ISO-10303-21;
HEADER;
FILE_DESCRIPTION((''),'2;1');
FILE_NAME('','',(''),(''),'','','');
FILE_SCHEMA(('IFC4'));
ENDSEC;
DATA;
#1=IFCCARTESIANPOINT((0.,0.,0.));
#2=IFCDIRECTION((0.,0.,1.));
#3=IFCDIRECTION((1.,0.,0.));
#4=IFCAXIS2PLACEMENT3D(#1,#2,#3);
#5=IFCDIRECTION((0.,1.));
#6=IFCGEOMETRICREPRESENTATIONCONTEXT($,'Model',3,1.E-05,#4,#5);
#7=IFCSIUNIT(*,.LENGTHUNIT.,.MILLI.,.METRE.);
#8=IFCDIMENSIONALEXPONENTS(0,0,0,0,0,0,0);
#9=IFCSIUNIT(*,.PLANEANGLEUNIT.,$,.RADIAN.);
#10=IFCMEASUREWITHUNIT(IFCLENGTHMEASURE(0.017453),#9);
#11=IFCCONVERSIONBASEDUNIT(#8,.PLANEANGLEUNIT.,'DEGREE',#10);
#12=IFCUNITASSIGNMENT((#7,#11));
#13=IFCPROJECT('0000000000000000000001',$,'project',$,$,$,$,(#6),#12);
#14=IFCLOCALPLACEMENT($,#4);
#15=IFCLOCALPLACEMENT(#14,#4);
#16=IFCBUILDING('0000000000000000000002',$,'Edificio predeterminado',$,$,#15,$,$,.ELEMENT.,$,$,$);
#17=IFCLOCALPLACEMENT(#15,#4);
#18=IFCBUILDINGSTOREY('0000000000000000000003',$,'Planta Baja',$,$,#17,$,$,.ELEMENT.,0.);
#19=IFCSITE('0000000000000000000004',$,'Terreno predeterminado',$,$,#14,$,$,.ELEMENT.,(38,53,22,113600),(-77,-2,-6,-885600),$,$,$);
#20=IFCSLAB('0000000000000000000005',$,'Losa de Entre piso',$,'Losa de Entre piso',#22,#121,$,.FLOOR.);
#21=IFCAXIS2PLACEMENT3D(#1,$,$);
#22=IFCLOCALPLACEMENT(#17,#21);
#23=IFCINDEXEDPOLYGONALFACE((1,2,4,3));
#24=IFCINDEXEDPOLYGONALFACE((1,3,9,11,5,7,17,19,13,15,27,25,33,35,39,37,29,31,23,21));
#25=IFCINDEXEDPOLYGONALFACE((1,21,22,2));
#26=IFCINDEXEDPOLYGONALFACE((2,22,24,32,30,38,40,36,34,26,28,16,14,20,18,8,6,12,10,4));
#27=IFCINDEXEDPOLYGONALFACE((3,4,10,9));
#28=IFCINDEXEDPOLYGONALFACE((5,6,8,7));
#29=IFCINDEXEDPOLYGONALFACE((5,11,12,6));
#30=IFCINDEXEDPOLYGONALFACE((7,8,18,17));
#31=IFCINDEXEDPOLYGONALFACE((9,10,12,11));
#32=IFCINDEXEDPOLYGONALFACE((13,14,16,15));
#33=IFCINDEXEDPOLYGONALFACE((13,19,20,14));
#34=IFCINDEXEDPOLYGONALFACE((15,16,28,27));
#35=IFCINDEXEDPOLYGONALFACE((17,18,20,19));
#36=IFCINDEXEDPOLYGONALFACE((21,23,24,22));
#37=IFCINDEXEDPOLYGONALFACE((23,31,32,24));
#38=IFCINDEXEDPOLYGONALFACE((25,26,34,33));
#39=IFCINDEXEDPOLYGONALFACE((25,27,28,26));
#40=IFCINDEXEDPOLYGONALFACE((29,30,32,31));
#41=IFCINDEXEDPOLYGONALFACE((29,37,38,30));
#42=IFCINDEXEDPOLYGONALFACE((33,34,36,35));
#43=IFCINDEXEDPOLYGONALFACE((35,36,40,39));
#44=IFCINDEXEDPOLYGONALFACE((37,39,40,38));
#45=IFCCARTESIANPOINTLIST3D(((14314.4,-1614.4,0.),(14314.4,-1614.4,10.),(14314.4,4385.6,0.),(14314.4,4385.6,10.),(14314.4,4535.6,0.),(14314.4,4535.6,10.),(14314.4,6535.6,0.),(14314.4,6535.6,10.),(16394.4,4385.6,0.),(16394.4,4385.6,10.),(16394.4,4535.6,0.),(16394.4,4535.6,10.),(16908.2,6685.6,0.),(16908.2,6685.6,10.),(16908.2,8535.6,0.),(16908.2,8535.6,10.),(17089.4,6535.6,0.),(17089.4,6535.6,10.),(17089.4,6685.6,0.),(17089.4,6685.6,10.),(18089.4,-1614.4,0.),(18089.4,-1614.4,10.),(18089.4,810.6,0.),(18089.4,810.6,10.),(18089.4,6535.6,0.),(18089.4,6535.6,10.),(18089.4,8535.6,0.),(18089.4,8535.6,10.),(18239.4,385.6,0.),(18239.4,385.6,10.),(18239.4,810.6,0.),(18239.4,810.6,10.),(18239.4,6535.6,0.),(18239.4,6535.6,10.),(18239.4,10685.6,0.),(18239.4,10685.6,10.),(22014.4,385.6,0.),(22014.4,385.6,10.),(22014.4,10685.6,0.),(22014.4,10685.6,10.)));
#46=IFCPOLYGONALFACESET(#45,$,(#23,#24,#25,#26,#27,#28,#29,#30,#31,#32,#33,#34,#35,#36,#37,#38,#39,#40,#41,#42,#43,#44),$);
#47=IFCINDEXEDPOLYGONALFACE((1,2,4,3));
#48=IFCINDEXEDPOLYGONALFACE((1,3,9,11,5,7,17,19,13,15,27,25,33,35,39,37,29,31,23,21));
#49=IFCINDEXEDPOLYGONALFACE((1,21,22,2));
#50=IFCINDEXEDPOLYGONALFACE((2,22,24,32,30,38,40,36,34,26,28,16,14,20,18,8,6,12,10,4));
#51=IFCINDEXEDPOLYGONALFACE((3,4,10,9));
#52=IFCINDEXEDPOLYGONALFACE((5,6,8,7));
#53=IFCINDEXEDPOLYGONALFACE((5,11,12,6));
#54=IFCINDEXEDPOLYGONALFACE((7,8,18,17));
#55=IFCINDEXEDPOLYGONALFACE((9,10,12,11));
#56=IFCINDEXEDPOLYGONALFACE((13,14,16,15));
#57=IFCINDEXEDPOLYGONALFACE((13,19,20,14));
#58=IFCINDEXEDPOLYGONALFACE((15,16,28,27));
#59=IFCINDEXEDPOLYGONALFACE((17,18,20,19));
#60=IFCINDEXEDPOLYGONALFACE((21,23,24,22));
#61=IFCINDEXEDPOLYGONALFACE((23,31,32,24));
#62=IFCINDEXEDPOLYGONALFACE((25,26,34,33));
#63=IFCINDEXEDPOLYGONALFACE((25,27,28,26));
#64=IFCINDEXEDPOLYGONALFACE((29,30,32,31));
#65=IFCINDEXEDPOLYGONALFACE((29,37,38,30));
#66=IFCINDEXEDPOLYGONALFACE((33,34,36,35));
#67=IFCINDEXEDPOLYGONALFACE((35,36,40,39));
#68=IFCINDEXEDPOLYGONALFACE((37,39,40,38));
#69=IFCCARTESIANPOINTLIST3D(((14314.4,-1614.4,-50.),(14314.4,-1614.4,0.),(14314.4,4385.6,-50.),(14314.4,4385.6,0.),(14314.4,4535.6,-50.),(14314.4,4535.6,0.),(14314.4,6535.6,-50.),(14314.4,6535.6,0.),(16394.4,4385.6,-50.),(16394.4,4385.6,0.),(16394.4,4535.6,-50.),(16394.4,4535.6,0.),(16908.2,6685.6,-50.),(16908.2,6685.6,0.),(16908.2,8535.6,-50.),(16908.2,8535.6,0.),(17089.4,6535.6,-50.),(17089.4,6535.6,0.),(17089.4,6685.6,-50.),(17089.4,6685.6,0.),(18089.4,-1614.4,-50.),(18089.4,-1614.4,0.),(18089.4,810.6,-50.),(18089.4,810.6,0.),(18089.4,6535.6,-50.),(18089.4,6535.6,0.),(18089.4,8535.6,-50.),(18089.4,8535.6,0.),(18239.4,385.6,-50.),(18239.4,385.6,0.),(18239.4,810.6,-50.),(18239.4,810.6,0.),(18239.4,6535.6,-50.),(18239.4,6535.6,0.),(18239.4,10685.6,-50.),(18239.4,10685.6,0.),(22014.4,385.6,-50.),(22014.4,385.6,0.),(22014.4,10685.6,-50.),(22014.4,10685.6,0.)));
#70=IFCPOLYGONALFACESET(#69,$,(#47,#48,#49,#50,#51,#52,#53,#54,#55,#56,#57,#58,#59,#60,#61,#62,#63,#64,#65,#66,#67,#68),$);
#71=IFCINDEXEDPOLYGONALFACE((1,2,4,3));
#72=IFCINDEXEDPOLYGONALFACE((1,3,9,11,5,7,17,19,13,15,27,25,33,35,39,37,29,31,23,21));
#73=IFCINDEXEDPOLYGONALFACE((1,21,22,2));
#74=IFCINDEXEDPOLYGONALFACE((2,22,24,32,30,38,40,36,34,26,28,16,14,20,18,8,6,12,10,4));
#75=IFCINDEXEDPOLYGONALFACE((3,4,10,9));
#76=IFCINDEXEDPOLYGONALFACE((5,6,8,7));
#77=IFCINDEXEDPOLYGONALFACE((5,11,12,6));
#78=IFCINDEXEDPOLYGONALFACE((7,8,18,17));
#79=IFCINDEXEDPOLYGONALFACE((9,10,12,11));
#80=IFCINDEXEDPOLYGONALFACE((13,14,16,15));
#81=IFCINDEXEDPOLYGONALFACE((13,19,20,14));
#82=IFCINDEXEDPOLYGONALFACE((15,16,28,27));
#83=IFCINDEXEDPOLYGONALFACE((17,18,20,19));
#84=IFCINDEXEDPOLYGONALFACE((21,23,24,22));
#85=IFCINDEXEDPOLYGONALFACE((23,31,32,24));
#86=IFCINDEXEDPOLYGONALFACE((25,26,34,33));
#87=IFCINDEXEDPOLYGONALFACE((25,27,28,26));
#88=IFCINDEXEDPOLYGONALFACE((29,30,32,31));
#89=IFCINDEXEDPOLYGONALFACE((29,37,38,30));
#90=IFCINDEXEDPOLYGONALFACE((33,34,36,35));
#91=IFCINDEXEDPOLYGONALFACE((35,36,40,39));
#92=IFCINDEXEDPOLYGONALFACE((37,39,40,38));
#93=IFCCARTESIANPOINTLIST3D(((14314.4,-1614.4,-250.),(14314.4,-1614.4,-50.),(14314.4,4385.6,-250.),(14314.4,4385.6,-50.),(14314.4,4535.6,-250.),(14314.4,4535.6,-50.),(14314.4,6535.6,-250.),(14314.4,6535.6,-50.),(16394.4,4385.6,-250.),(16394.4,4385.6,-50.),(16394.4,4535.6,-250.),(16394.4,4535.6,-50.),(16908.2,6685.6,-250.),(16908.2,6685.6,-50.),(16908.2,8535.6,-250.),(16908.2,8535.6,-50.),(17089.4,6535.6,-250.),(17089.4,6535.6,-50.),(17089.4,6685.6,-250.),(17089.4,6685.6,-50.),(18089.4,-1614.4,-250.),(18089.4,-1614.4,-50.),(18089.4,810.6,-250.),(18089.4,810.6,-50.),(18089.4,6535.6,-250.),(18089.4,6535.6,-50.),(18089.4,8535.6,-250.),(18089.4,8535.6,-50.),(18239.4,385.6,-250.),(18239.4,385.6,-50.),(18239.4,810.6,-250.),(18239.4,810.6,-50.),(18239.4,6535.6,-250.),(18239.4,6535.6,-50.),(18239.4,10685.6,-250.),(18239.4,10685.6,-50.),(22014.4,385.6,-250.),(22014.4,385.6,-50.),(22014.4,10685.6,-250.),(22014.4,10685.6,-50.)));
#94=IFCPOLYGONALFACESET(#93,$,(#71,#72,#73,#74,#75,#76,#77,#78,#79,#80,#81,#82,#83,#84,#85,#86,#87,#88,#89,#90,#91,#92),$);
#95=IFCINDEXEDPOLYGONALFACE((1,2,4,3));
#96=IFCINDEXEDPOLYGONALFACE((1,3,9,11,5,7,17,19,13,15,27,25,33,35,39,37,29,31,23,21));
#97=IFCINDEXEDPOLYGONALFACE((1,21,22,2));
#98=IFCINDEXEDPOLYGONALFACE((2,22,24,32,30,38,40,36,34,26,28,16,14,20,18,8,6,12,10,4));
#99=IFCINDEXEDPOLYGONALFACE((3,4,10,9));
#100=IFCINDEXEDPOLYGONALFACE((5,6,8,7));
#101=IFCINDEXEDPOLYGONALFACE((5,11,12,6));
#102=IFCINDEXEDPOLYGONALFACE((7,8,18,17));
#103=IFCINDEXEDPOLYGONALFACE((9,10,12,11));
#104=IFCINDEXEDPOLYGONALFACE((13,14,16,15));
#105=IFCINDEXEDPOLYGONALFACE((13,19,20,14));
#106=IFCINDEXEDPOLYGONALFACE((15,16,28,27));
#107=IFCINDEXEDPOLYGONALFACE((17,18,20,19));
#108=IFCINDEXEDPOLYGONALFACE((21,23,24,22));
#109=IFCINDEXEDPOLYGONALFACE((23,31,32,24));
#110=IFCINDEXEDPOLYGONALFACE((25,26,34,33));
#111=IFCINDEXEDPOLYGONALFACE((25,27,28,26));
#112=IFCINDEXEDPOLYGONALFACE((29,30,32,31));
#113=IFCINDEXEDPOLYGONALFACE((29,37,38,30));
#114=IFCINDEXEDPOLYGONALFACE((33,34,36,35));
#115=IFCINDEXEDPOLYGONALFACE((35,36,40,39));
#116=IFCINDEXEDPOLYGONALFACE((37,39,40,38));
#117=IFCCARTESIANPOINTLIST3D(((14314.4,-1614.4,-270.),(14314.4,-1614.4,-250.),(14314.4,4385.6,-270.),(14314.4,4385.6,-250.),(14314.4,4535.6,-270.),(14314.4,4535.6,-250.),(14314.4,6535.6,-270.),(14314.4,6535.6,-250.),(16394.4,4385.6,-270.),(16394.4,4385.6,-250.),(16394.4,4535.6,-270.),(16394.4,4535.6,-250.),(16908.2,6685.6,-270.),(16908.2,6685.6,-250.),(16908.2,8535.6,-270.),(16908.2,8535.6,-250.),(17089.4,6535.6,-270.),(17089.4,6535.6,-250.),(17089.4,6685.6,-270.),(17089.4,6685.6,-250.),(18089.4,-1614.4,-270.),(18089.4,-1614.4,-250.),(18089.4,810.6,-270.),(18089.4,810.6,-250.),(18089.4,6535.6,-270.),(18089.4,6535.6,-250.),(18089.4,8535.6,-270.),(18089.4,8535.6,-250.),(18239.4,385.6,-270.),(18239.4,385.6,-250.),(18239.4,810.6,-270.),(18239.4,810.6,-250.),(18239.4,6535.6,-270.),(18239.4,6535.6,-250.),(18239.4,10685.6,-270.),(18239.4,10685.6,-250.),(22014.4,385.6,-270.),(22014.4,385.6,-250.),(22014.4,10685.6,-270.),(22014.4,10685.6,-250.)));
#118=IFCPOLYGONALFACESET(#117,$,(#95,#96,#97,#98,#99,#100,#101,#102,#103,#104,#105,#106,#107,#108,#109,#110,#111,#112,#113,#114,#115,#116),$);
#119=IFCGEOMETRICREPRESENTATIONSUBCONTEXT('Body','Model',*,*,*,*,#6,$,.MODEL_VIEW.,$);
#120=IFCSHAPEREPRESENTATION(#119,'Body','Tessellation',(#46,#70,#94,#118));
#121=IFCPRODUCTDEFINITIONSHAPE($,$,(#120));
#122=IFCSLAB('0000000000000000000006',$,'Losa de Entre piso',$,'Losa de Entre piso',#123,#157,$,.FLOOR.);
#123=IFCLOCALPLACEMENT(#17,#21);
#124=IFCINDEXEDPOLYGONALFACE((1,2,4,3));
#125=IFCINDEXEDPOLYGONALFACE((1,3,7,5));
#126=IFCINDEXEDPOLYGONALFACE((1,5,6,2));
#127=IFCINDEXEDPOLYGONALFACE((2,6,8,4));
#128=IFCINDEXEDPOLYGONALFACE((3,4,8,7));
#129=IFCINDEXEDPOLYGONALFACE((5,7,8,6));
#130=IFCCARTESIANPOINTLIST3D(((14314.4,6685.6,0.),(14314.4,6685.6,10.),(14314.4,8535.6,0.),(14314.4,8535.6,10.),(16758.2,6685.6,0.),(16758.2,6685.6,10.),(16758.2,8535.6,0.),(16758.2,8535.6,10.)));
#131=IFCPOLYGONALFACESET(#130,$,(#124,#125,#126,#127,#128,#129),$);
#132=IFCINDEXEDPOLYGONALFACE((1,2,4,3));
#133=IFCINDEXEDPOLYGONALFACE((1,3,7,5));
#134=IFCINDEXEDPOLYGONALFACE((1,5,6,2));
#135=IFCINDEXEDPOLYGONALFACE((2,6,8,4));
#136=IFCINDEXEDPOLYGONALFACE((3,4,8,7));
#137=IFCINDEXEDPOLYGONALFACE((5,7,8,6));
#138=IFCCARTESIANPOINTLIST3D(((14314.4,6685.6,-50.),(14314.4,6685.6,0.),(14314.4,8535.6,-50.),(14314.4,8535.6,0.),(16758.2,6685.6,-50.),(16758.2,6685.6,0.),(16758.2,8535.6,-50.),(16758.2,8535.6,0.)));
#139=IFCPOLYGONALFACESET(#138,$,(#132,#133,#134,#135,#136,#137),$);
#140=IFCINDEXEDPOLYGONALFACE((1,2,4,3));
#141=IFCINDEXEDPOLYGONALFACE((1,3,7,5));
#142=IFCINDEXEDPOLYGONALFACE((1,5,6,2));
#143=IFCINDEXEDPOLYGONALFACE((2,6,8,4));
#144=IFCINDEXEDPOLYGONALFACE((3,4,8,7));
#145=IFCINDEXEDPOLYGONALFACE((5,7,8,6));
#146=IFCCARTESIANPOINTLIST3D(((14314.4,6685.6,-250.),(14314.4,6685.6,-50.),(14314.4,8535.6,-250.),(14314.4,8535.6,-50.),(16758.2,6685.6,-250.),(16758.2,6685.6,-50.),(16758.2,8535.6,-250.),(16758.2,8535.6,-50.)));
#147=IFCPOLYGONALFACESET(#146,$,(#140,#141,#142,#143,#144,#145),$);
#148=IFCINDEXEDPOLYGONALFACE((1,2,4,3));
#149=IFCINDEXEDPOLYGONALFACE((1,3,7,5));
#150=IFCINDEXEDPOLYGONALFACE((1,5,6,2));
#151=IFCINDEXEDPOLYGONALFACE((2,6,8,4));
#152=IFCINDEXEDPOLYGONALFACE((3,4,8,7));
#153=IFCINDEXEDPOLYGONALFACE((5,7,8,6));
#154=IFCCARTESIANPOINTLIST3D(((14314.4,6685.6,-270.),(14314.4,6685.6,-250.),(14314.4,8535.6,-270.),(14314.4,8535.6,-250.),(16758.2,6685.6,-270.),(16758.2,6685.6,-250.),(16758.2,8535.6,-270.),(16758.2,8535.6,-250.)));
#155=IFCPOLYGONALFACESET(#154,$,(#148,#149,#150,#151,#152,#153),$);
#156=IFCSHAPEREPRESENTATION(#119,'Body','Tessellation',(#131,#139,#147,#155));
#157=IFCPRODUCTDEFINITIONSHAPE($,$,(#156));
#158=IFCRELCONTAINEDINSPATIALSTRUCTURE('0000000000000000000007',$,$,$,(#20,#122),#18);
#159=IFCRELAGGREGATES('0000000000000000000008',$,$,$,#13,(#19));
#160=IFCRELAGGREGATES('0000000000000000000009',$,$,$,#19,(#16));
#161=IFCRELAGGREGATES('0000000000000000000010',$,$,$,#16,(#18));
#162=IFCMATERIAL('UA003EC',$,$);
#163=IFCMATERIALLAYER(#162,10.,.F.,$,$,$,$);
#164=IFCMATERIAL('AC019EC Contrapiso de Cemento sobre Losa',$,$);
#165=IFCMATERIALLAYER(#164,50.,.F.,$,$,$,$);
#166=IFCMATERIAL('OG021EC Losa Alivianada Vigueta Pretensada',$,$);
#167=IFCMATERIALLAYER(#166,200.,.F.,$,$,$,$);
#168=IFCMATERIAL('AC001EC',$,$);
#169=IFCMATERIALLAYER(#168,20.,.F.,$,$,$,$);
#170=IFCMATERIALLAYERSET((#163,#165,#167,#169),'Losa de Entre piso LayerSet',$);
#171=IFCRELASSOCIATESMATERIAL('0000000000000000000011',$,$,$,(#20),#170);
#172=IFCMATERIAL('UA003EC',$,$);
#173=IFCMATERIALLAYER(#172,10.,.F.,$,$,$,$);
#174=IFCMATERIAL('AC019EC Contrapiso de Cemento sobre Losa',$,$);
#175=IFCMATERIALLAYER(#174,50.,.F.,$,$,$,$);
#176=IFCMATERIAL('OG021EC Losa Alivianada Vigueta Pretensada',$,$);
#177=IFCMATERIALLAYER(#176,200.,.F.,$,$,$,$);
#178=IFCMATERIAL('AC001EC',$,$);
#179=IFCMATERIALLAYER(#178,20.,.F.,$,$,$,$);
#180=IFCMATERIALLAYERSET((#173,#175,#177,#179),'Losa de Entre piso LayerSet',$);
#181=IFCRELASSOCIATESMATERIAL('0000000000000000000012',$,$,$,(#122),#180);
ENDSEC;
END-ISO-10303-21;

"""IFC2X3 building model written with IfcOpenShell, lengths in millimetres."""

from ifc_helpers import new_model, entity, si_unit, converted_unit, direction, frame, origin_with_axes, place, context, subcontext, project, spatial, polyline, outline, extrude, material, layer, layer_set, layer_usage, element, save


model = new_model("IFC2X3")

# Units and contexts
model_context = context("Model", 3, precision=1e-05, world=origin_with_axes(), true_north=direction((0.0, 1.0)))
body_context = subcontext(model_context, "Body", "Model", "MODEL_VIEW")
ifc_project = project(units=[si_unit("LENGTHUNIT", "METRE", prefix="MILLI"), converted_unit("PLANEANGLEUNIT", "DEGREE", entity("IfcLengthMeasure", 0.017453), si_unit("PLANEANGLEUNIT", "RADIAN"), dimensions=[0, 0, 0, 0, 0, 0, 0])], contexts=[model_context])

# Site, building, storey
site_placement = place(None, origin_with_axes())
site = spatial("IfcSite", under=ifc_project, at=site_placement, Name="Terreno predeterminado", CompositionType="ELEMENT", RefLatitude=(38, 53, 22, 113600), RefLongitude=(-77, -2, -6, -885600))
building_placement = place(site_placement, origin_with_axes())
building = spatial("IfcBuilding", under=site, at=building_placement, Name="Edificio predeterminado", CompositionType="ELEMENT")
storey_placement = place(building_placement, origin_with_axes())
storey = spatial("IfcBuildingStorey", under=building, at=storey_placement, Name="Planta Baja", CompositionType="ELEMENT", Elevation=0.0)

# Slabs
ifc_material_1 = material(Name="UA003EC")
ifc_layer_1 = layer(ifc_material_1, 10.0, ventilated=False)
ifc_material_2 = material(Name="AC019EC Contrapiso de Cemento sobre Losa")
ifc_layer_2 = layer(ifc_material_2, 50.0, ventilated=False)
ifc_material_3 = material(Name="OG021EC Losa Alivianada Vigueta Pretensada")
ifc_layer_3 = layer(ifc_material_3, 200.0, ventilated=False)
ifc_material_4 = material(Name="AC001EC")
ifc_layer_4 = layer(ifc_material_4, 20.0, ventilated=False)
ifc_layer_set_1 = layer_set([ifc_layer_1, ifc_layer_2, ifc_layer_3, ifc_layer_4], Name="Losa de Entre piso LayerSet")
ifc_layer_usage_1 = layer_usage(ifc_layer_set_1, "AXIS3", "POSITIVE", 0.0)
slab_1_placement = place(storey_placement, origin_with_axes())
element("IfcSlab", 1, at=slab_1_placement, inside=storey, material=ifc_layer_usage_1, Name="Losa de Entre piso", ObjectType="Losa de Entre piso", PredefinedType="FLOOR", context=body_context, shape_type="SweptSolid", body=[
    extrude(outline(polyline([(0.0, -6000.0), (3775.0, -6000.0), (3775.0, -3575.0), (3925.0, -3575.0), (3925.0, -4000.0), (7700.0, -4000.0), (7700.0, 6300.0), (3925.0, 6300.0), (3925.0, 2150.0), (3775.0, 2150.0), (3775.0, 4150.0), (2593.9, 4150.0), (2593.9, 2300.0), (2775.0, 2300.0), (2775.0, 2150.0), (0.0, 2150.0), (0.0, 150.0), (2080.0, 150.0), (2080.0, 0.0), (0.0, 0.0), (0.0, -6000.0)])), frame((14314.4, 4385.6, 0.0), z_axis=(0.0, 0.0, 1.0), x_axis=(1.0, 0.0, 0.0)), (0.0, 0.0, 1.0), 10.0),
    extrude(outline(polyline([(0.0, -6000.0), (3775.0, -6000.0), (3775.0, -3575.0), (3925.0, -3575.0), (3925.0, -4000.0), (7700.0, -4000.0), (7700.0, 6300.0), (3925.0, 6300.0), (3925.0, 2150.0), (3775.0, 2150.0), (3775.0, 4150.0), (2593.9, 4150.0), (2593.9, 2300.0), (2775.0, 2300.0), (2775.0, 2150.0), (0.0, 2150.0), (0.0, 150.0), (2080.0, 150.0), (2080.0, 0.0), (0.0, 0.0), (0.0, -6000.0)])), frame((14314.4, 4385.6, -50.0), z_axis=(0.0, 0.0, 1.0), x_axis=(1.0, 0.0, 0.0)), (0.0, 0.0, 1.0), 50.0),
    extrude(outline(polyline([(0.0, -6000.0), (3775.0, -6000.0), (3775.0, -3575.0), (3925.0, -3575.0), (3925.0, -4000.0), (7700.0, -4000.0), (7700.0, 6300.0), (3925.0, 6300.0), (3925.0, 2150.0), (3775.0, 2150.0), (3775.0, 4150.0), (2593.9, 4150.0), (2593.9, 2300.0), (2775.0, 2300.0), (2775.0, 2150.0), (0.0, 2150.0), (0.0, 150.0), (2080.0, 150.0), (2080.0, 0.0), (0.0, 0.0), (0.0, -6000.0)])), frame((14314.4, 4385.6, -250.0), z_axis=(0.0, 0.0, 1.0), x_axis=(1.0, 0.0, 0.0)), (0.0, 0.0, 1.0), 200.0),
    extrude(outline(polyline([(0.0, -6000.0), (3775.0, -6000.0), (3775.0, -3575.0), (3925.0, -3575.0), (3925.0, -4000.0), (7700.0, -4000.0), (7700.0, 6300.0), (3925.0, 6300.0), (3925.0, 2150.0), (3775.0, 2150.0), (3775.0, 4150.0), (2593.9, 4150.0), (2593.9, 2300.0), (2775.0, 2300.0), (2775.0, 2150.0), (0.0, 2150.0), (0.0, 150.0), (2080.0, 150.0), (2080.0, 0.0), (0.0, 0.0), (0.0, -6000.0)])), frame((14314.4, 4385.6, -270.0), z_axis=(0.0, 0.0, 1.0), x_axis=(1.0, 0.0, 0.0)), (0.0, 0.0, 1.0), 20.0),
])
ifc_material_5 = material(Name="UA003EC")
ifc_layer_5 = layer(ifc_material_5, 10.0, ventilated=False)
ifc_material_6 = material(Name="AC019EC Contrapiso de Cemento sobre Losa")
ifc_layer_6 = layer(ifc_material_6, 50.0, ventilated=False)
ifc_material_7 = material(Name="OG021EC Losa Alivianada Vigueta Pretensada")
ifc_layer_7 = layer(ifc_material_7, 200.0, ventilated=False)
ifc_material_8 = material(Name="AC001EC")
ifc_layer_8 = layer(ifc_material_8, 20.0, ventilated=False)
ifc_layer_set_2 = layer_set([ifc_layer_5, ifc_layer_6, ifc_layer_7, ifc_layer_8], Name="Losa de Entre piso LayerSet")
ifc_layer_usage_2 = layer_usage(ifc_layer_set_2, "AXIS3", "NEGATIVE", 0.0)
slab_2_placement = place(storey_placement, origin_with_axes())
element("IfcSlab", 2, at=slab_2_placement, inside=storey, material=ifc_layer_usage_2, Name="Losa de Entre piso", ObjectType="Losa de Entre piso", PredefinedType="FLOOR", context=body_context, shape_type="SweptSolid", body=[
    extrude(outline(polyline([(0.0, 2443.9), (1850.0, 2443.9), (1850.0, 0.0), (0.0, 0.0), (0.0, 2443.9)])), frame((14314.4, 6685.6, 0.0), z_axis=(0.0, 0.0, -1.0), x_axis=(0.0, 1.0, 0.0)), (0.0, 0.0, -1.0), 10.0),
    extrude(outline(polyline([(0.0, 2443.9), (1850.0, 2443.9), (1850.0, 0.0), (0.0, 0.0), (0.0, 2443.9)])), frame((14314.4, 6685.6, -50.0), z_axis=(0.0, 0.0, -1.0), x_axis=(0.0, 1.0, 0.0)), (0.0, 0.0, -1.0), 50.0),
    extrude(outline(polyline([(0.0, 2443.9), (1850.0, 2443.9), (1850.0, 0.0), (0.0, 0.0), (0.0, 2443.9)])), frame((14314.4, 6685.6, -250.0), z_axis=(0.0, 0.0, -1.0), x_axis=(0.0, 1.0, 0.0)), (0.0, 0.0, -1.0), 200.0),
    extrude(outline(polyline([(0.0, 2443.9), (1850.0, 2443.9), (1850.0, 0.0), (0.0, 0.0), (0.0, 2443.9)])), frame((14314.4, 6685.6, -270.0), z_axis=(0.0, 0.0, -1.0), x_axis=(0.0, 1.0, 0.0)), (0.0, 0.0, -1.0), 20.0),
])

save(model, "model.ifc")
